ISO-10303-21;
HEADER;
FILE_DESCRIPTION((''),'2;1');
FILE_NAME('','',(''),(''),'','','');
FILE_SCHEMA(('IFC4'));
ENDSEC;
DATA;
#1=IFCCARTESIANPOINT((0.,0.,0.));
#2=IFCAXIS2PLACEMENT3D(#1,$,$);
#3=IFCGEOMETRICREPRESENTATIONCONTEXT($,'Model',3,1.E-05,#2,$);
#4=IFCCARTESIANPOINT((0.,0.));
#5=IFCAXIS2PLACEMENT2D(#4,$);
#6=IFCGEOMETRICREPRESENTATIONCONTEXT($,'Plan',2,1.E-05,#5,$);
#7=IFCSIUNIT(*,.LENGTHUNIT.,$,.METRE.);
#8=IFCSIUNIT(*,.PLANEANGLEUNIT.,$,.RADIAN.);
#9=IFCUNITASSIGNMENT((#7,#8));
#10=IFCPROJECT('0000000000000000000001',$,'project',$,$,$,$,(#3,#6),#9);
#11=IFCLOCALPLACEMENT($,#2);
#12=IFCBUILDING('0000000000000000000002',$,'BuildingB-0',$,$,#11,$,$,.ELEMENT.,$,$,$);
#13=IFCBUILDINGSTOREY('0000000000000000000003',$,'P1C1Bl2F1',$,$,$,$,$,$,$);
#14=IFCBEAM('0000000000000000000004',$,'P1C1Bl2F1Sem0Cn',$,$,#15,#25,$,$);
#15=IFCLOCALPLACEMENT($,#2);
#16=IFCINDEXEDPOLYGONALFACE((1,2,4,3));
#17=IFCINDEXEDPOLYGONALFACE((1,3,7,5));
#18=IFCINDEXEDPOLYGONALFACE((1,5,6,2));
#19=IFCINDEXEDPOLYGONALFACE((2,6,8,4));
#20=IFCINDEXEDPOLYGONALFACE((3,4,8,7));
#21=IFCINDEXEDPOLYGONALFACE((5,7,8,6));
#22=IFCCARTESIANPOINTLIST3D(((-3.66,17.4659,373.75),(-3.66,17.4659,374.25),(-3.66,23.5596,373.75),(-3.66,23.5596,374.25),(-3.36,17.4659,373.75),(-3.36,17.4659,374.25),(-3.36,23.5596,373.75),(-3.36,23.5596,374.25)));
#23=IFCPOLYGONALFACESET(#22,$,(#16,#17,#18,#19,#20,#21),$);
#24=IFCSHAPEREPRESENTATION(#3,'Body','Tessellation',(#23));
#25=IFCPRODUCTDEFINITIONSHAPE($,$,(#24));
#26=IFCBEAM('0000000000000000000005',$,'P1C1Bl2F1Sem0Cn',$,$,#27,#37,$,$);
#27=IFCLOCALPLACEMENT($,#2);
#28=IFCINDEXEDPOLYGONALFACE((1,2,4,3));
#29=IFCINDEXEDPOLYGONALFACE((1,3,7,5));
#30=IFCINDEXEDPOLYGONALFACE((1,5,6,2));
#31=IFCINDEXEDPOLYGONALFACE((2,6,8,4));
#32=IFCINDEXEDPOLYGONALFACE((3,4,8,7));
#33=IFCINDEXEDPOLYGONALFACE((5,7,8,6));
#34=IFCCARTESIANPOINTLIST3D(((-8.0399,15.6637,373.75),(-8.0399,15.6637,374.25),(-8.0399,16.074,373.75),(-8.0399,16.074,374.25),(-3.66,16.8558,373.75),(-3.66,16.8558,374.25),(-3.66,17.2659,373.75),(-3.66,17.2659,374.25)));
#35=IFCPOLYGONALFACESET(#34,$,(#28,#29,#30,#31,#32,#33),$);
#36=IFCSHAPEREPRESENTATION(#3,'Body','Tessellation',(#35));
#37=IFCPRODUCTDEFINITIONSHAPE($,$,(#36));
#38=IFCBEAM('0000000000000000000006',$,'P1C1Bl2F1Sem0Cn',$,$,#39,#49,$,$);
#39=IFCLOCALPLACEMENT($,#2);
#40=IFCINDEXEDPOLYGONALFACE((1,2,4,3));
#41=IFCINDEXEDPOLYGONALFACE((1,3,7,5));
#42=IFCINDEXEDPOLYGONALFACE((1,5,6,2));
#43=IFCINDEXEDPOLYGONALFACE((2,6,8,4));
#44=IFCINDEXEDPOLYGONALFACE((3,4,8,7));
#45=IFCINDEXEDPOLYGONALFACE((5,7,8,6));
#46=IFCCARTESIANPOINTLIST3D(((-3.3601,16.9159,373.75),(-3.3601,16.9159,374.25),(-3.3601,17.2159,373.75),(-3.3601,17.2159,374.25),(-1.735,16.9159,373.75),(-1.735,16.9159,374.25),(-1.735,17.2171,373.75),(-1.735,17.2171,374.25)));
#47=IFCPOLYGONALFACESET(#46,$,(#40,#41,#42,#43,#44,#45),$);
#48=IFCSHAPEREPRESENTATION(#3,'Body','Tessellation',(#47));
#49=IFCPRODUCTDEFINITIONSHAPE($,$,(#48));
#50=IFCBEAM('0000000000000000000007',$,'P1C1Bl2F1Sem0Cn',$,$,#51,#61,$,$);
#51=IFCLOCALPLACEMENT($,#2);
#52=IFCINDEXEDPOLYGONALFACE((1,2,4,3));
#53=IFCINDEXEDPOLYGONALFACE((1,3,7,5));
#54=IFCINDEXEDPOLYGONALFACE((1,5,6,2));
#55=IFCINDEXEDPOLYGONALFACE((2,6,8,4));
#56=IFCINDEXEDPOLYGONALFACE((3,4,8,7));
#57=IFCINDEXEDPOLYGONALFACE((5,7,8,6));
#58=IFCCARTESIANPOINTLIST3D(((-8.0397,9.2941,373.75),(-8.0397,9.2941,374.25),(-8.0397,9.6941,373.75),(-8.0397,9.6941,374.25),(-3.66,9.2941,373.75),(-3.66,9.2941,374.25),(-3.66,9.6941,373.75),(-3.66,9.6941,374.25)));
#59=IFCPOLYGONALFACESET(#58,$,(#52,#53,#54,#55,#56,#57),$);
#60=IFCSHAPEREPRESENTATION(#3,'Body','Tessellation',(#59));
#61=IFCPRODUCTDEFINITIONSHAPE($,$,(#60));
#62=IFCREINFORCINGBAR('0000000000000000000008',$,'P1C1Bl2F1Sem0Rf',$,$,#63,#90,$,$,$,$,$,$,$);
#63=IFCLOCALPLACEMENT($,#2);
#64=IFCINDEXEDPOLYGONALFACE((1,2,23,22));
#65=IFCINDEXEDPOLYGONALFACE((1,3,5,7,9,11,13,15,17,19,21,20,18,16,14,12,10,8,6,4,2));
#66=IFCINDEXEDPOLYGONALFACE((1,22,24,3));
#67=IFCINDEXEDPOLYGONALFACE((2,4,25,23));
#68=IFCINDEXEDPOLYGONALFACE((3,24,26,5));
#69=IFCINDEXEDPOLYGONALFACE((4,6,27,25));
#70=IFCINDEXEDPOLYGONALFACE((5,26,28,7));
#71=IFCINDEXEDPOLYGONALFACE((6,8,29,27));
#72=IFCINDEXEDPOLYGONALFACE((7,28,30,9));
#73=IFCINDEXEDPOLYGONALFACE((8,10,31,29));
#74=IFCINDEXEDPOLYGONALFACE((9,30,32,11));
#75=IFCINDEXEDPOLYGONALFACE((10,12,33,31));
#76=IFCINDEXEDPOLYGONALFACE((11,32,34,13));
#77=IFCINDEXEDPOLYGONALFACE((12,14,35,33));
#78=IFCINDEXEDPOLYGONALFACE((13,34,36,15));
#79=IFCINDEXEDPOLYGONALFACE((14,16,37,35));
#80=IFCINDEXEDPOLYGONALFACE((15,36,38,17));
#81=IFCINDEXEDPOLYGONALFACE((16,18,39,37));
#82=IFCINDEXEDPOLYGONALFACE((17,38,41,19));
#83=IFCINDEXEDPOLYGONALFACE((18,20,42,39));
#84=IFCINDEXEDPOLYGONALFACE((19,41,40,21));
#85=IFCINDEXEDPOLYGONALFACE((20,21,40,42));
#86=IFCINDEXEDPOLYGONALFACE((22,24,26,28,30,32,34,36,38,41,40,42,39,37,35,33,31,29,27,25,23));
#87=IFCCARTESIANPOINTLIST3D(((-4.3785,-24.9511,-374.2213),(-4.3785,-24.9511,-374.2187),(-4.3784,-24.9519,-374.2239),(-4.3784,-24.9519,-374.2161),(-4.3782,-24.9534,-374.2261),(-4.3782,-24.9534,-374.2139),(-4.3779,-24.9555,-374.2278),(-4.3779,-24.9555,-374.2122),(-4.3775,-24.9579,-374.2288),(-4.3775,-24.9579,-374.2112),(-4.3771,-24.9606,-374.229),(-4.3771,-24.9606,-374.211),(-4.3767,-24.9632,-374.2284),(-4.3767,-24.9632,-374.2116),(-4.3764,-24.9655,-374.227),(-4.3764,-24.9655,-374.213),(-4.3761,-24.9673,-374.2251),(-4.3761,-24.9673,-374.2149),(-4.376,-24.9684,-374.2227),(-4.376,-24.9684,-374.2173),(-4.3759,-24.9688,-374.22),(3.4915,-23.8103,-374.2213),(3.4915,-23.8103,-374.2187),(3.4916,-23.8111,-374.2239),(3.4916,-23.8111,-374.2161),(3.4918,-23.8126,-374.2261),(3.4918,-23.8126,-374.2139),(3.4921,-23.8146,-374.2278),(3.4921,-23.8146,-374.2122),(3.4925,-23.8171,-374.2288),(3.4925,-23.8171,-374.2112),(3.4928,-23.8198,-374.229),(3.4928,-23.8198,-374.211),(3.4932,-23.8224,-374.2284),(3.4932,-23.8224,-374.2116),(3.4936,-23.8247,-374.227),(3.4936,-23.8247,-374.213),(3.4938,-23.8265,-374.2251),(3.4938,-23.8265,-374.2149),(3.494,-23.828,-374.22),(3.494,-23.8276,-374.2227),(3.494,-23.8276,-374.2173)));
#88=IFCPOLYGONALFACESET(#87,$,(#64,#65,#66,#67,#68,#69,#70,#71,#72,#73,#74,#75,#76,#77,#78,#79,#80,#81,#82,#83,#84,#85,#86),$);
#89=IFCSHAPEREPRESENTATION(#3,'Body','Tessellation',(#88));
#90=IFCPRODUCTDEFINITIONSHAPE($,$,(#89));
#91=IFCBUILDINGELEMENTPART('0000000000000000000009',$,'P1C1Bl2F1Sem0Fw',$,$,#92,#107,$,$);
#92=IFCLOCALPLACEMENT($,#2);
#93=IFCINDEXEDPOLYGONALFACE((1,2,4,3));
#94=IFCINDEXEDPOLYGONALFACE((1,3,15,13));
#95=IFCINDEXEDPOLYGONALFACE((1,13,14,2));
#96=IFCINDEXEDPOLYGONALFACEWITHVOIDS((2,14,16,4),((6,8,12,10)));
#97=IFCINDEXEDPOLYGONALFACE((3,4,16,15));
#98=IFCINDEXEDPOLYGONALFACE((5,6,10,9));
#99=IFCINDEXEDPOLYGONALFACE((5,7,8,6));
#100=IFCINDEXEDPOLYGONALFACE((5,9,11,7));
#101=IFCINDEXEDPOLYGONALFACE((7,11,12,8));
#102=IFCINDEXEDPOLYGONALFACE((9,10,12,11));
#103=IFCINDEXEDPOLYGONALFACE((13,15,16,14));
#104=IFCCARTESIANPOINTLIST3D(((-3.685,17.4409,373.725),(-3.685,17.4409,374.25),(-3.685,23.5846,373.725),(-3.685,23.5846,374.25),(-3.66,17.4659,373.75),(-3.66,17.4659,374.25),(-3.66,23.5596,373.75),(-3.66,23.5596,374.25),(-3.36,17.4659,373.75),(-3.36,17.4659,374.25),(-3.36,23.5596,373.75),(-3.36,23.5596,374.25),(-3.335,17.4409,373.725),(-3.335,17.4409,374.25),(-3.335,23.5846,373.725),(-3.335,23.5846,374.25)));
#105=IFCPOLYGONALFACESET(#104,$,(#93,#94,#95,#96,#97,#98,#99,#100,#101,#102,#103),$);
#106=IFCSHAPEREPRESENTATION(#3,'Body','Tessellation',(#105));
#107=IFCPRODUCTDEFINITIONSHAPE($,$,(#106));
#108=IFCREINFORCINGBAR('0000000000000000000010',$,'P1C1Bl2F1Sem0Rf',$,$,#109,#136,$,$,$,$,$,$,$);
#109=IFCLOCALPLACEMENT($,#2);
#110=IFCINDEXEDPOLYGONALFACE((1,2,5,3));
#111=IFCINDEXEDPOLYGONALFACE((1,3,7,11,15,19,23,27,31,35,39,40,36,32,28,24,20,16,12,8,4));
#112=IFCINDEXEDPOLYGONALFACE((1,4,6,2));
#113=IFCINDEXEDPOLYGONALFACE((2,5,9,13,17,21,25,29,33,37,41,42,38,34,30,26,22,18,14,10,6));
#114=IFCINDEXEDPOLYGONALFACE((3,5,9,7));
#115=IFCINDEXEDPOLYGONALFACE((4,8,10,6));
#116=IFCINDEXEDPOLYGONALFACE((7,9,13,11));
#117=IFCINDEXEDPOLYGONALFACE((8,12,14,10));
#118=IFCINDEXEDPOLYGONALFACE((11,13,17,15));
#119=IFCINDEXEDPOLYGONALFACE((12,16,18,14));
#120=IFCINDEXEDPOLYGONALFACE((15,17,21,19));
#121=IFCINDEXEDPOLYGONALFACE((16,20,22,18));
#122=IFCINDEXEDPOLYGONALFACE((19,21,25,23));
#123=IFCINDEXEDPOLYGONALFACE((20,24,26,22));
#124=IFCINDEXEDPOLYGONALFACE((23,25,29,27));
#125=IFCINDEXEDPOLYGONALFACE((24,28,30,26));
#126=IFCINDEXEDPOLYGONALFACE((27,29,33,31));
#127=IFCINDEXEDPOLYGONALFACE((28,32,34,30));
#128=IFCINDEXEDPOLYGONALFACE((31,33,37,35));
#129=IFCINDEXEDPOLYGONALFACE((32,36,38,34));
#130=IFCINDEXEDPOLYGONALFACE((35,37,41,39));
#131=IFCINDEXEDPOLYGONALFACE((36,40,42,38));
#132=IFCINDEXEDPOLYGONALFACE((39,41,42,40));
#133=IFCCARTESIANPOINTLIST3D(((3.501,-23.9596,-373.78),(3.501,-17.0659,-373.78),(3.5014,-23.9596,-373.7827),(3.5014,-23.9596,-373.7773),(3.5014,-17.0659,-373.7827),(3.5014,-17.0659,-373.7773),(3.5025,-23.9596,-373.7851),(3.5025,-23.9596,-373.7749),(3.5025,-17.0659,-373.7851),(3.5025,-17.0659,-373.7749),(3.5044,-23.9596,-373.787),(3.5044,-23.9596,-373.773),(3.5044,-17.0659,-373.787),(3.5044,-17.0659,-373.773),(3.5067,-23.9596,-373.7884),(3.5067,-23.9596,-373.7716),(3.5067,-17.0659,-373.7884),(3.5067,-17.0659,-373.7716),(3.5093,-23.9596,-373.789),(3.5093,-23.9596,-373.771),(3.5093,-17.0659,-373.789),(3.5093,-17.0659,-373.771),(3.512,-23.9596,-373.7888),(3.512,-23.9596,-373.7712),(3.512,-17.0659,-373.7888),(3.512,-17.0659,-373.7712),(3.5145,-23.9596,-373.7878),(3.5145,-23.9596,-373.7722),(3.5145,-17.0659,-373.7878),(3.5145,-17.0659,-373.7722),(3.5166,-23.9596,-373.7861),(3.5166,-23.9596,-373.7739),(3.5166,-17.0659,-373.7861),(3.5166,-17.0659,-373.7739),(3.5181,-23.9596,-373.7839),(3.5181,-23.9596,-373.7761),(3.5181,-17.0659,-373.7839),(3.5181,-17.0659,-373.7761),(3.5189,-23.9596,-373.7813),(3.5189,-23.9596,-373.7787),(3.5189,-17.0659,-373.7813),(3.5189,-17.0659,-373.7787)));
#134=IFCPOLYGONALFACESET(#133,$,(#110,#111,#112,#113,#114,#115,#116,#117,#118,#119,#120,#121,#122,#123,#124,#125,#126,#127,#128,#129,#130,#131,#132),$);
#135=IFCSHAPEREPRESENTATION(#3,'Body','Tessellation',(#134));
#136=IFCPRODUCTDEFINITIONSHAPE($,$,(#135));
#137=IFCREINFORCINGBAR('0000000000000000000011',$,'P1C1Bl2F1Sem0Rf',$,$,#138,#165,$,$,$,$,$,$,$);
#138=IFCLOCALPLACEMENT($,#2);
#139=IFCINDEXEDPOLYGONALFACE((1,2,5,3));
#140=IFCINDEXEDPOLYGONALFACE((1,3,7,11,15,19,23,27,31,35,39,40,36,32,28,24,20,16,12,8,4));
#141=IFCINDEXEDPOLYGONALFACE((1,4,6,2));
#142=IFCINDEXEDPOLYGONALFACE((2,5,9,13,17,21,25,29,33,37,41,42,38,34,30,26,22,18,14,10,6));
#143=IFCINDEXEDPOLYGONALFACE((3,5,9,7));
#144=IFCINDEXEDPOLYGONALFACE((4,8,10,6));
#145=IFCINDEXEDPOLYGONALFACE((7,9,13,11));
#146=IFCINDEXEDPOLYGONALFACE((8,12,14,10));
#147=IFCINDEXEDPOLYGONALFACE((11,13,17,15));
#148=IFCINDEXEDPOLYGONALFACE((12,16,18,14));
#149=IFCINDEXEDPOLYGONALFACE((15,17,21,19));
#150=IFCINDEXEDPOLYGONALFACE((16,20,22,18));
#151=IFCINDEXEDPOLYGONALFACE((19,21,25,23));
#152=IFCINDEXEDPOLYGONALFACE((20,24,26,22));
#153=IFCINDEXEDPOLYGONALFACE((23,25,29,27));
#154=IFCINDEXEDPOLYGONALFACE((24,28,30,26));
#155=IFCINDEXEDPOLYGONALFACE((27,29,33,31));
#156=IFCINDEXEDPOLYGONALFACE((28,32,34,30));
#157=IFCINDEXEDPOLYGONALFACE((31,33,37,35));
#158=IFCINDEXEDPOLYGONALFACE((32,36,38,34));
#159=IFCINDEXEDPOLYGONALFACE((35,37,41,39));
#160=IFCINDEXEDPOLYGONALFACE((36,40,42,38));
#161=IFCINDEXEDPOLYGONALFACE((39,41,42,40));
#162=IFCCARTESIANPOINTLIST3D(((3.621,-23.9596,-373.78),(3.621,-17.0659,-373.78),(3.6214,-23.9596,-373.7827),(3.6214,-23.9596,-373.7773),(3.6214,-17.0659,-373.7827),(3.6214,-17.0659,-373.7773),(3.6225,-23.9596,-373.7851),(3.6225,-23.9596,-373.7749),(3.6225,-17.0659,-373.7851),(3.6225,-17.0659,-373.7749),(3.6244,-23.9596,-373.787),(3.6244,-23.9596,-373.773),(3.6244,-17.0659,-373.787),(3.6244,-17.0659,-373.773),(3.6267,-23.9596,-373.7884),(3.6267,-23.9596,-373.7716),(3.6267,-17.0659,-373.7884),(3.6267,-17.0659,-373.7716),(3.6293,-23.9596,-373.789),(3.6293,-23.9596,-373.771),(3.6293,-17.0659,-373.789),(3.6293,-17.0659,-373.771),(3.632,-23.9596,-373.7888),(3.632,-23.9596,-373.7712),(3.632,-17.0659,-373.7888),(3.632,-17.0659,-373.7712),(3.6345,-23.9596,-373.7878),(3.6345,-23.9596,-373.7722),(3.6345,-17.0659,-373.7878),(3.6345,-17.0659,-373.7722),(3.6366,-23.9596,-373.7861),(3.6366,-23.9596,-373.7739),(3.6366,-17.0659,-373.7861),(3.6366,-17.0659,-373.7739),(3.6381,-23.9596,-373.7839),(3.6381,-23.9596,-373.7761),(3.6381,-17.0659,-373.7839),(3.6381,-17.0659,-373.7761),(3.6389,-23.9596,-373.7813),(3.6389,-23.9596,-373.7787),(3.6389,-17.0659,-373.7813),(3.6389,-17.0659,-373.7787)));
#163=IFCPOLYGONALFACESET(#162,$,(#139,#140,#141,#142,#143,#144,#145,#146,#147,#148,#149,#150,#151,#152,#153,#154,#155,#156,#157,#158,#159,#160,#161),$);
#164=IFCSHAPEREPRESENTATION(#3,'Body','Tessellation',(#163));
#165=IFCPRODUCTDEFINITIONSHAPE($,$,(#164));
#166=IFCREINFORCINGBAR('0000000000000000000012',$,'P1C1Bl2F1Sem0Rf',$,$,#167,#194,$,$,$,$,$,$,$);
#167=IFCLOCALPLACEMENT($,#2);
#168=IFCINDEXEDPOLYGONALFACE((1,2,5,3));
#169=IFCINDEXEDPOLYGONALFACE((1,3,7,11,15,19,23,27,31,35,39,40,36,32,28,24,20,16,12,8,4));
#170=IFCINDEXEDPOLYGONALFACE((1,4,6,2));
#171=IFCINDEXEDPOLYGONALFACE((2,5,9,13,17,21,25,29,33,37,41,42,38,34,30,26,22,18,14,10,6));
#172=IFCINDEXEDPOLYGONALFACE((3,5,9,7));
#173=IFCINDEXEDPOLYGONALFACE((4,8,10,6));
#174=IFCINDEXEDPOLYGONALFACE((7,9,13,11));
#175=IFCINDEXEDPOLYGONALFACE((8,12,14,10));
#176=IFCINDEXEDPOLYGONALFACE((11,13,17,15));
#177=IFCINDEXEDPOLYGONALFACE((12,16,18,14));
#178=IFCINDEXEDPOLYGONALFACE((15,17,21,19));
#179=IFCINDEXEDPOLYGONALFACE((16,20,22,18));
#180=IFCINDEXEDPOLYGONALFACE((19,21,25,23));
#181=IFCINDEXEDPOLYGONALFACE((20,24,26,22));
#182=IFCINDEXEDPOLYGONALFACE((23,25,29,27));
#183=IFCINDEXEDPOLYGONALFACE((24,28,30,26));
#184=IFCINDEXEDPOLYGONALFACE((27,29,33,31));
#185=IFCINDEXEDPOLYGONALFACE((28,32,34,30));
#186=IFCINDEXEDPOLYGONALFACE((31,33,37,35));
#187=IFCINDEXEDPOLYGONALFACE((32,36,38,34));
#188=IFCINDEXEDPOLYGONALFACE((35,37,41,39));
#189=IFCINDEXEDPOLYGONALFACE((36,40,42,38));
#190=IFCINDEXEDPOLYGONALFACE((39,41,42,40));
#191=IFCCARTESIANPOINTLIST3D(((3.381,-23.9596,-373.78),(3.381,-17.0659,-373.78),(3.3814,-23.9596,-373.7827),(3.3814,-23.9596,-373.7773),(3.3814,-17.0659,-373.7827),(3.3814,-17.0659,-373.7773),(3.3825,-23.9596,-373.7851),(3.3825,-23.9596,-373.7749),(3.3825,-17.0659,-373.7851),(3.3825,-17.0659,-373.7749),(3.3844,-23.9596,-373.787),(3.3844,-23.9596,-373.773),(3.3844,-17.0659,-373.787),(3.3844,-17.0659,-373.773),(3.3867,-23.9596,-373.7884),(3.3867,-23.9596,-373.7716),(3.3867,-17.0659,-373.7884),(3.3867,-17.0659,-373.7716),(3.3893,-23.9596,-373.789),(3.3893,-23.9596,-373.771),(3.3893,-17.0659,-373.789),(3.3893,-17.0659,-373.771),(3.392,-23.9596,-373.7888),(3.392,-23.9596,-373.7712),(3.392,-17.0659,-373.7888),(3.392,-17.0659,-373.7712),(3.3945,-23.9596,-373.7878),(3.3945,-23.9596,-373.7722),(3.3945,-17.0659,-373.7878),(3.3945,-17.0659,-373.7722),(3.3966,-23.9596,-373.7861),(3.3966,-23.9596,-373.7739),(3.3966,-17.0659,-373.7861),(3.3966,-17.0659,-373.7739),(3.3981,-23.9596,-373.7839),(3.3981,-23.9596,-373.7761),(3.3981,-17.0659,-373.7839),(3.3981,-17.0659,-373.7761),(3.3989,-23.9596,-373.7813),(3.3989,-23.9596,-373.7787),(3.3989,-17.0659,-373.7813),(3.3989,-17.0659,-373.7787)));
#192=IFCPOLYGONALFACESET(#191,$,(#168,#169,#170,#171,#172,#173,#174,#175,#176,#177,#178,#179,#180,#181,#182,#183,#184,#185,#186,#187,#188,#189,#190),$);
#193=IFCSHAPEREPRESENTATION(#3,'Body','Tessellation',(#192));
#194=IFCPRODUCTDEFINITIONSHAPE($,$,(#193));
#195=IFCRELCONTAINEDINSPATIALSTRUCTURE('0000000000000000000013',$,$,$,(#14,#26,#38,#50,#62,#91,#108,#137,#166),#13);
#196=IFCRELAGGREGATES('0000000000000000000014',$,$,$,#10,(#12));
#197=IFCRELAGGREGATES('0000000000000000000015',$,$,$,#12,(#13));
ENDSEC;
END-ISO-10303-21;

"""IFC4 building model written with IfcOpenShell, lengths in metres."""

from ifc_helpers import new_model, entity, si_unit, origin, origin_2d, place, context, project, spatial, polyline, outline, extrude, element, save


model = new_model("IFC4")

# Units and contexts
model_context = context("Model", 3, precision=1e-05, world=origin())
plan_context = context("Plan", 2, precision=1e-05, world=origin_2d())
ifc_project = project(units=[si_unit("LENGTHUNIT", "METRE"), si_unit("PLANEANGLEUNIT", "RADIAN")], contexts=[model_context, plan_context])

# Building, storey
building_placement = place(None, origin())
building = spatial("IfcBuilding", under=ifc_project, at=building_placement, Name="BuildingB-0", CompositionType="ELEMENT")
storey = spatial("IfcBuildingStorey", under=building, Name="P1C1Bl2F1")

# Beams
element("IfcBeam", 1, inside=storey, Name="P1C1Bl2F1Sem0Cn", context=model_context, shape_type="SweptSolid", body=[
    extrude(outline(polyline([(-3.66, 23.5596, 373.75), (-3.36, 23.5596, 373.75), (-3.36, 17.4659, 373.75), (-3.66, 17.4659, 373.75), (-3.66, 23.5596, 373.75)])), None, (0.0, 0.0, 1.0), 0.5),
])
element("IfcBeam", 2, inside=storey, Name="P1C1Bl2F1Sem0Cn", context=model_context, shape_type="SweptSolid", body=[
    extrude(outline(polyline([(-8.0399, 15.6637, 373.75), (-8.0399, 16.074, 373.75), (-3.66, 17.2659, 373.75), (-3.66, 16.8558, 373.75), (-8.0399, 15.6637, 373.75)])), None, (0.0, 0.0, 1.0), 0.5),
])
element("IfcBeam", 3, inside=storey, Name="P1C1Bl2F1Sem0Cn", context=model_context, shape_type="SweptSolid", body=[
    extrude(outline(polyline([(-3.3601, 17.2159, 373.75), (-3.3601, 16.9159, 373.75), (-1.735, 16.9159, 373.75), (-1.735, 17.2171, 373.75), (-3.3601, 17.2159, 373.75)])), None, (0.0, 0.0, 1.0), 0.5),
])
element("IfcBeam", 4, inside=storey, Name="P1C1Bl2F1Sem0Cn", context=model_context, shape_type="SweptSolid", body=[
    extrude(outline(polyline([(-8.0397, 9.6941, 373.75), (-8.0397, 9.2941, 373.75), (-3.66, 9.2941, 373.75), (-3.66, 9.6941, 373.75), (-8.0397, 9.6941, 373.75)])), None, (0.0, 0.0, 1.0), 0.5),
])

# Reinforcing bar
element("IfcReinforcingBar", 5, inside=storey, Name="P1C1Bl2F1Sem0Rf", context=model_context, shape_type="SweptSolid", body=[
    entity("IfcSurfaceCurveSweptAreaSolid", entity("IfcCircleProfileDef", "AREA", None, None, 0.009), None, entity("IfcPolyline", [entity("IfcCartesianPoint", [4.3772, 24.9599, 374.22]), entity("IfcCartesianPoint", [-3.4927, 23.8191, 374.22])]), None, None, entity("IfcPlane", entity("IfcAxis2Placement3D", entity("IfcCartesianPoint", [4.3772, 24.9599, 374.22]), entity("IfcDirection", [0.0, 0.0, 1.0]), entity("IfcDirection", [1.0, 0.0, 0.0])))),
])

# Building element part, opening
building_element_part_1 = element("IfcBuildingElementPart", 6, inside=storey, Name="P1C1Bl2F1Sem0Fw", context=model_context, shape_type="SweptSolid", body=[
    extrude(outline(polyline([(-3.685, 23.5846, 373.725), (-3.335, 23.5846, 373.725), (-3.335, 17.4409, 373.725), (-3.685, 17.4409, 373.725), (-3.685, 23.5846, 373.725)])), None, (0.0, 0.0, 1.0), 0.525),
])
element("IfcOpeningElement", 7, inside=storey, cuts=building_element_part_1, context=model_context, shape_type="SweptSolid", body=[
    extrude(outline(polyline([(-3.66, 23.5596, 373.75), (-3.36, 23.5596, 373.75), (-3.36, 17.4659, 373.75), (-3.66, 17.4659, 373.75), (-3.66, 23.5596, 373.75)])), None, (0.0, 0.0, 1.0), 0.5),
])

# Reinforcing bars
element("IfcReinforcingBar", 8, inside=storey, Name="P1C1Bl2F1Sem0Rf", context=model_context, shape_type="SweptSolid", body=[
    entity("IfcSurfaceCurveSweptAreaSolid", entity("IfcCircleProfileDef", "AREA", None, None, 0.009), None, entity("IfcPolyline", [entity("IfcCartesianPoint", [-3.51, 23.9596, 373.78]), entity("IfcCartesianPoint", [-3.51, 17.0659, 373.78])]), None, None, entity("IfcPlane", entity("IfcAxis2Placement3D", entity("IfcCartesianPoint", [-3.51, 23.9596, 373.78]), entity("IfcDirection", [0.0, 0.0, 1.0]), entity("IfcDirection", [1.0, 0.0, 0.0])))),
])
element("IfcReinforcingBar", 9, inside=storey, Name="P1C1Bl2F1Sem0Rf", context=model_context, shape_type="SweptSolid", body=[
    entity("IfcSurfaceCurveSweptAreaSolid", entity("IfcCircleProfileDef", "AREA", None, None, 0.009), None, entity("IfcPolyline", [entity("IfcCartesianPoint", [-3.63, 23.9596, 373.78]), entity("IfcCartesianPoint", [-3.63, 17.0659, 373.78])]), None, None, entity("IfcPlane", entity("IfcAxis2Placement3D", entity("IfcCartesianPoint", [-3.63, 23.9596, 373.78]), entity("IfcDirection", [0.0, 0.0, 1.0]), entity("IfcDirection", [1.0, 0.0, 0.0])))),
])
element("IfcReinforcingBar", 10, inside=storey, Name="P1C1Bl2F1Sem0Rf", context=model_context, shape_type="SweptSolid", body=[
    entity("IfcSurfaceCurveSweptAreaSolid", entity("IfcCircleProfileDef", "AREA", None, None, 0.009), None, entity("IfcPolyline", [entity("IfcCartesianPoint", [-3.39, 23.9596, 373.78]), entity("IfcCartesianPoint", [-3.39, 17.0659, 373.78])]), None, None, entity("IfcPlane", entity("IfcAxis2Placement3D", entity("IfcCartesianPoint", [-3.39, 23.9596, 373.78]), entity("IfcDirection", [0.0, 0.0, 1.0]), entity("IfcDirection", [1.0, 0.0, 0.0])))),
])

save(model, "model.ifc")
